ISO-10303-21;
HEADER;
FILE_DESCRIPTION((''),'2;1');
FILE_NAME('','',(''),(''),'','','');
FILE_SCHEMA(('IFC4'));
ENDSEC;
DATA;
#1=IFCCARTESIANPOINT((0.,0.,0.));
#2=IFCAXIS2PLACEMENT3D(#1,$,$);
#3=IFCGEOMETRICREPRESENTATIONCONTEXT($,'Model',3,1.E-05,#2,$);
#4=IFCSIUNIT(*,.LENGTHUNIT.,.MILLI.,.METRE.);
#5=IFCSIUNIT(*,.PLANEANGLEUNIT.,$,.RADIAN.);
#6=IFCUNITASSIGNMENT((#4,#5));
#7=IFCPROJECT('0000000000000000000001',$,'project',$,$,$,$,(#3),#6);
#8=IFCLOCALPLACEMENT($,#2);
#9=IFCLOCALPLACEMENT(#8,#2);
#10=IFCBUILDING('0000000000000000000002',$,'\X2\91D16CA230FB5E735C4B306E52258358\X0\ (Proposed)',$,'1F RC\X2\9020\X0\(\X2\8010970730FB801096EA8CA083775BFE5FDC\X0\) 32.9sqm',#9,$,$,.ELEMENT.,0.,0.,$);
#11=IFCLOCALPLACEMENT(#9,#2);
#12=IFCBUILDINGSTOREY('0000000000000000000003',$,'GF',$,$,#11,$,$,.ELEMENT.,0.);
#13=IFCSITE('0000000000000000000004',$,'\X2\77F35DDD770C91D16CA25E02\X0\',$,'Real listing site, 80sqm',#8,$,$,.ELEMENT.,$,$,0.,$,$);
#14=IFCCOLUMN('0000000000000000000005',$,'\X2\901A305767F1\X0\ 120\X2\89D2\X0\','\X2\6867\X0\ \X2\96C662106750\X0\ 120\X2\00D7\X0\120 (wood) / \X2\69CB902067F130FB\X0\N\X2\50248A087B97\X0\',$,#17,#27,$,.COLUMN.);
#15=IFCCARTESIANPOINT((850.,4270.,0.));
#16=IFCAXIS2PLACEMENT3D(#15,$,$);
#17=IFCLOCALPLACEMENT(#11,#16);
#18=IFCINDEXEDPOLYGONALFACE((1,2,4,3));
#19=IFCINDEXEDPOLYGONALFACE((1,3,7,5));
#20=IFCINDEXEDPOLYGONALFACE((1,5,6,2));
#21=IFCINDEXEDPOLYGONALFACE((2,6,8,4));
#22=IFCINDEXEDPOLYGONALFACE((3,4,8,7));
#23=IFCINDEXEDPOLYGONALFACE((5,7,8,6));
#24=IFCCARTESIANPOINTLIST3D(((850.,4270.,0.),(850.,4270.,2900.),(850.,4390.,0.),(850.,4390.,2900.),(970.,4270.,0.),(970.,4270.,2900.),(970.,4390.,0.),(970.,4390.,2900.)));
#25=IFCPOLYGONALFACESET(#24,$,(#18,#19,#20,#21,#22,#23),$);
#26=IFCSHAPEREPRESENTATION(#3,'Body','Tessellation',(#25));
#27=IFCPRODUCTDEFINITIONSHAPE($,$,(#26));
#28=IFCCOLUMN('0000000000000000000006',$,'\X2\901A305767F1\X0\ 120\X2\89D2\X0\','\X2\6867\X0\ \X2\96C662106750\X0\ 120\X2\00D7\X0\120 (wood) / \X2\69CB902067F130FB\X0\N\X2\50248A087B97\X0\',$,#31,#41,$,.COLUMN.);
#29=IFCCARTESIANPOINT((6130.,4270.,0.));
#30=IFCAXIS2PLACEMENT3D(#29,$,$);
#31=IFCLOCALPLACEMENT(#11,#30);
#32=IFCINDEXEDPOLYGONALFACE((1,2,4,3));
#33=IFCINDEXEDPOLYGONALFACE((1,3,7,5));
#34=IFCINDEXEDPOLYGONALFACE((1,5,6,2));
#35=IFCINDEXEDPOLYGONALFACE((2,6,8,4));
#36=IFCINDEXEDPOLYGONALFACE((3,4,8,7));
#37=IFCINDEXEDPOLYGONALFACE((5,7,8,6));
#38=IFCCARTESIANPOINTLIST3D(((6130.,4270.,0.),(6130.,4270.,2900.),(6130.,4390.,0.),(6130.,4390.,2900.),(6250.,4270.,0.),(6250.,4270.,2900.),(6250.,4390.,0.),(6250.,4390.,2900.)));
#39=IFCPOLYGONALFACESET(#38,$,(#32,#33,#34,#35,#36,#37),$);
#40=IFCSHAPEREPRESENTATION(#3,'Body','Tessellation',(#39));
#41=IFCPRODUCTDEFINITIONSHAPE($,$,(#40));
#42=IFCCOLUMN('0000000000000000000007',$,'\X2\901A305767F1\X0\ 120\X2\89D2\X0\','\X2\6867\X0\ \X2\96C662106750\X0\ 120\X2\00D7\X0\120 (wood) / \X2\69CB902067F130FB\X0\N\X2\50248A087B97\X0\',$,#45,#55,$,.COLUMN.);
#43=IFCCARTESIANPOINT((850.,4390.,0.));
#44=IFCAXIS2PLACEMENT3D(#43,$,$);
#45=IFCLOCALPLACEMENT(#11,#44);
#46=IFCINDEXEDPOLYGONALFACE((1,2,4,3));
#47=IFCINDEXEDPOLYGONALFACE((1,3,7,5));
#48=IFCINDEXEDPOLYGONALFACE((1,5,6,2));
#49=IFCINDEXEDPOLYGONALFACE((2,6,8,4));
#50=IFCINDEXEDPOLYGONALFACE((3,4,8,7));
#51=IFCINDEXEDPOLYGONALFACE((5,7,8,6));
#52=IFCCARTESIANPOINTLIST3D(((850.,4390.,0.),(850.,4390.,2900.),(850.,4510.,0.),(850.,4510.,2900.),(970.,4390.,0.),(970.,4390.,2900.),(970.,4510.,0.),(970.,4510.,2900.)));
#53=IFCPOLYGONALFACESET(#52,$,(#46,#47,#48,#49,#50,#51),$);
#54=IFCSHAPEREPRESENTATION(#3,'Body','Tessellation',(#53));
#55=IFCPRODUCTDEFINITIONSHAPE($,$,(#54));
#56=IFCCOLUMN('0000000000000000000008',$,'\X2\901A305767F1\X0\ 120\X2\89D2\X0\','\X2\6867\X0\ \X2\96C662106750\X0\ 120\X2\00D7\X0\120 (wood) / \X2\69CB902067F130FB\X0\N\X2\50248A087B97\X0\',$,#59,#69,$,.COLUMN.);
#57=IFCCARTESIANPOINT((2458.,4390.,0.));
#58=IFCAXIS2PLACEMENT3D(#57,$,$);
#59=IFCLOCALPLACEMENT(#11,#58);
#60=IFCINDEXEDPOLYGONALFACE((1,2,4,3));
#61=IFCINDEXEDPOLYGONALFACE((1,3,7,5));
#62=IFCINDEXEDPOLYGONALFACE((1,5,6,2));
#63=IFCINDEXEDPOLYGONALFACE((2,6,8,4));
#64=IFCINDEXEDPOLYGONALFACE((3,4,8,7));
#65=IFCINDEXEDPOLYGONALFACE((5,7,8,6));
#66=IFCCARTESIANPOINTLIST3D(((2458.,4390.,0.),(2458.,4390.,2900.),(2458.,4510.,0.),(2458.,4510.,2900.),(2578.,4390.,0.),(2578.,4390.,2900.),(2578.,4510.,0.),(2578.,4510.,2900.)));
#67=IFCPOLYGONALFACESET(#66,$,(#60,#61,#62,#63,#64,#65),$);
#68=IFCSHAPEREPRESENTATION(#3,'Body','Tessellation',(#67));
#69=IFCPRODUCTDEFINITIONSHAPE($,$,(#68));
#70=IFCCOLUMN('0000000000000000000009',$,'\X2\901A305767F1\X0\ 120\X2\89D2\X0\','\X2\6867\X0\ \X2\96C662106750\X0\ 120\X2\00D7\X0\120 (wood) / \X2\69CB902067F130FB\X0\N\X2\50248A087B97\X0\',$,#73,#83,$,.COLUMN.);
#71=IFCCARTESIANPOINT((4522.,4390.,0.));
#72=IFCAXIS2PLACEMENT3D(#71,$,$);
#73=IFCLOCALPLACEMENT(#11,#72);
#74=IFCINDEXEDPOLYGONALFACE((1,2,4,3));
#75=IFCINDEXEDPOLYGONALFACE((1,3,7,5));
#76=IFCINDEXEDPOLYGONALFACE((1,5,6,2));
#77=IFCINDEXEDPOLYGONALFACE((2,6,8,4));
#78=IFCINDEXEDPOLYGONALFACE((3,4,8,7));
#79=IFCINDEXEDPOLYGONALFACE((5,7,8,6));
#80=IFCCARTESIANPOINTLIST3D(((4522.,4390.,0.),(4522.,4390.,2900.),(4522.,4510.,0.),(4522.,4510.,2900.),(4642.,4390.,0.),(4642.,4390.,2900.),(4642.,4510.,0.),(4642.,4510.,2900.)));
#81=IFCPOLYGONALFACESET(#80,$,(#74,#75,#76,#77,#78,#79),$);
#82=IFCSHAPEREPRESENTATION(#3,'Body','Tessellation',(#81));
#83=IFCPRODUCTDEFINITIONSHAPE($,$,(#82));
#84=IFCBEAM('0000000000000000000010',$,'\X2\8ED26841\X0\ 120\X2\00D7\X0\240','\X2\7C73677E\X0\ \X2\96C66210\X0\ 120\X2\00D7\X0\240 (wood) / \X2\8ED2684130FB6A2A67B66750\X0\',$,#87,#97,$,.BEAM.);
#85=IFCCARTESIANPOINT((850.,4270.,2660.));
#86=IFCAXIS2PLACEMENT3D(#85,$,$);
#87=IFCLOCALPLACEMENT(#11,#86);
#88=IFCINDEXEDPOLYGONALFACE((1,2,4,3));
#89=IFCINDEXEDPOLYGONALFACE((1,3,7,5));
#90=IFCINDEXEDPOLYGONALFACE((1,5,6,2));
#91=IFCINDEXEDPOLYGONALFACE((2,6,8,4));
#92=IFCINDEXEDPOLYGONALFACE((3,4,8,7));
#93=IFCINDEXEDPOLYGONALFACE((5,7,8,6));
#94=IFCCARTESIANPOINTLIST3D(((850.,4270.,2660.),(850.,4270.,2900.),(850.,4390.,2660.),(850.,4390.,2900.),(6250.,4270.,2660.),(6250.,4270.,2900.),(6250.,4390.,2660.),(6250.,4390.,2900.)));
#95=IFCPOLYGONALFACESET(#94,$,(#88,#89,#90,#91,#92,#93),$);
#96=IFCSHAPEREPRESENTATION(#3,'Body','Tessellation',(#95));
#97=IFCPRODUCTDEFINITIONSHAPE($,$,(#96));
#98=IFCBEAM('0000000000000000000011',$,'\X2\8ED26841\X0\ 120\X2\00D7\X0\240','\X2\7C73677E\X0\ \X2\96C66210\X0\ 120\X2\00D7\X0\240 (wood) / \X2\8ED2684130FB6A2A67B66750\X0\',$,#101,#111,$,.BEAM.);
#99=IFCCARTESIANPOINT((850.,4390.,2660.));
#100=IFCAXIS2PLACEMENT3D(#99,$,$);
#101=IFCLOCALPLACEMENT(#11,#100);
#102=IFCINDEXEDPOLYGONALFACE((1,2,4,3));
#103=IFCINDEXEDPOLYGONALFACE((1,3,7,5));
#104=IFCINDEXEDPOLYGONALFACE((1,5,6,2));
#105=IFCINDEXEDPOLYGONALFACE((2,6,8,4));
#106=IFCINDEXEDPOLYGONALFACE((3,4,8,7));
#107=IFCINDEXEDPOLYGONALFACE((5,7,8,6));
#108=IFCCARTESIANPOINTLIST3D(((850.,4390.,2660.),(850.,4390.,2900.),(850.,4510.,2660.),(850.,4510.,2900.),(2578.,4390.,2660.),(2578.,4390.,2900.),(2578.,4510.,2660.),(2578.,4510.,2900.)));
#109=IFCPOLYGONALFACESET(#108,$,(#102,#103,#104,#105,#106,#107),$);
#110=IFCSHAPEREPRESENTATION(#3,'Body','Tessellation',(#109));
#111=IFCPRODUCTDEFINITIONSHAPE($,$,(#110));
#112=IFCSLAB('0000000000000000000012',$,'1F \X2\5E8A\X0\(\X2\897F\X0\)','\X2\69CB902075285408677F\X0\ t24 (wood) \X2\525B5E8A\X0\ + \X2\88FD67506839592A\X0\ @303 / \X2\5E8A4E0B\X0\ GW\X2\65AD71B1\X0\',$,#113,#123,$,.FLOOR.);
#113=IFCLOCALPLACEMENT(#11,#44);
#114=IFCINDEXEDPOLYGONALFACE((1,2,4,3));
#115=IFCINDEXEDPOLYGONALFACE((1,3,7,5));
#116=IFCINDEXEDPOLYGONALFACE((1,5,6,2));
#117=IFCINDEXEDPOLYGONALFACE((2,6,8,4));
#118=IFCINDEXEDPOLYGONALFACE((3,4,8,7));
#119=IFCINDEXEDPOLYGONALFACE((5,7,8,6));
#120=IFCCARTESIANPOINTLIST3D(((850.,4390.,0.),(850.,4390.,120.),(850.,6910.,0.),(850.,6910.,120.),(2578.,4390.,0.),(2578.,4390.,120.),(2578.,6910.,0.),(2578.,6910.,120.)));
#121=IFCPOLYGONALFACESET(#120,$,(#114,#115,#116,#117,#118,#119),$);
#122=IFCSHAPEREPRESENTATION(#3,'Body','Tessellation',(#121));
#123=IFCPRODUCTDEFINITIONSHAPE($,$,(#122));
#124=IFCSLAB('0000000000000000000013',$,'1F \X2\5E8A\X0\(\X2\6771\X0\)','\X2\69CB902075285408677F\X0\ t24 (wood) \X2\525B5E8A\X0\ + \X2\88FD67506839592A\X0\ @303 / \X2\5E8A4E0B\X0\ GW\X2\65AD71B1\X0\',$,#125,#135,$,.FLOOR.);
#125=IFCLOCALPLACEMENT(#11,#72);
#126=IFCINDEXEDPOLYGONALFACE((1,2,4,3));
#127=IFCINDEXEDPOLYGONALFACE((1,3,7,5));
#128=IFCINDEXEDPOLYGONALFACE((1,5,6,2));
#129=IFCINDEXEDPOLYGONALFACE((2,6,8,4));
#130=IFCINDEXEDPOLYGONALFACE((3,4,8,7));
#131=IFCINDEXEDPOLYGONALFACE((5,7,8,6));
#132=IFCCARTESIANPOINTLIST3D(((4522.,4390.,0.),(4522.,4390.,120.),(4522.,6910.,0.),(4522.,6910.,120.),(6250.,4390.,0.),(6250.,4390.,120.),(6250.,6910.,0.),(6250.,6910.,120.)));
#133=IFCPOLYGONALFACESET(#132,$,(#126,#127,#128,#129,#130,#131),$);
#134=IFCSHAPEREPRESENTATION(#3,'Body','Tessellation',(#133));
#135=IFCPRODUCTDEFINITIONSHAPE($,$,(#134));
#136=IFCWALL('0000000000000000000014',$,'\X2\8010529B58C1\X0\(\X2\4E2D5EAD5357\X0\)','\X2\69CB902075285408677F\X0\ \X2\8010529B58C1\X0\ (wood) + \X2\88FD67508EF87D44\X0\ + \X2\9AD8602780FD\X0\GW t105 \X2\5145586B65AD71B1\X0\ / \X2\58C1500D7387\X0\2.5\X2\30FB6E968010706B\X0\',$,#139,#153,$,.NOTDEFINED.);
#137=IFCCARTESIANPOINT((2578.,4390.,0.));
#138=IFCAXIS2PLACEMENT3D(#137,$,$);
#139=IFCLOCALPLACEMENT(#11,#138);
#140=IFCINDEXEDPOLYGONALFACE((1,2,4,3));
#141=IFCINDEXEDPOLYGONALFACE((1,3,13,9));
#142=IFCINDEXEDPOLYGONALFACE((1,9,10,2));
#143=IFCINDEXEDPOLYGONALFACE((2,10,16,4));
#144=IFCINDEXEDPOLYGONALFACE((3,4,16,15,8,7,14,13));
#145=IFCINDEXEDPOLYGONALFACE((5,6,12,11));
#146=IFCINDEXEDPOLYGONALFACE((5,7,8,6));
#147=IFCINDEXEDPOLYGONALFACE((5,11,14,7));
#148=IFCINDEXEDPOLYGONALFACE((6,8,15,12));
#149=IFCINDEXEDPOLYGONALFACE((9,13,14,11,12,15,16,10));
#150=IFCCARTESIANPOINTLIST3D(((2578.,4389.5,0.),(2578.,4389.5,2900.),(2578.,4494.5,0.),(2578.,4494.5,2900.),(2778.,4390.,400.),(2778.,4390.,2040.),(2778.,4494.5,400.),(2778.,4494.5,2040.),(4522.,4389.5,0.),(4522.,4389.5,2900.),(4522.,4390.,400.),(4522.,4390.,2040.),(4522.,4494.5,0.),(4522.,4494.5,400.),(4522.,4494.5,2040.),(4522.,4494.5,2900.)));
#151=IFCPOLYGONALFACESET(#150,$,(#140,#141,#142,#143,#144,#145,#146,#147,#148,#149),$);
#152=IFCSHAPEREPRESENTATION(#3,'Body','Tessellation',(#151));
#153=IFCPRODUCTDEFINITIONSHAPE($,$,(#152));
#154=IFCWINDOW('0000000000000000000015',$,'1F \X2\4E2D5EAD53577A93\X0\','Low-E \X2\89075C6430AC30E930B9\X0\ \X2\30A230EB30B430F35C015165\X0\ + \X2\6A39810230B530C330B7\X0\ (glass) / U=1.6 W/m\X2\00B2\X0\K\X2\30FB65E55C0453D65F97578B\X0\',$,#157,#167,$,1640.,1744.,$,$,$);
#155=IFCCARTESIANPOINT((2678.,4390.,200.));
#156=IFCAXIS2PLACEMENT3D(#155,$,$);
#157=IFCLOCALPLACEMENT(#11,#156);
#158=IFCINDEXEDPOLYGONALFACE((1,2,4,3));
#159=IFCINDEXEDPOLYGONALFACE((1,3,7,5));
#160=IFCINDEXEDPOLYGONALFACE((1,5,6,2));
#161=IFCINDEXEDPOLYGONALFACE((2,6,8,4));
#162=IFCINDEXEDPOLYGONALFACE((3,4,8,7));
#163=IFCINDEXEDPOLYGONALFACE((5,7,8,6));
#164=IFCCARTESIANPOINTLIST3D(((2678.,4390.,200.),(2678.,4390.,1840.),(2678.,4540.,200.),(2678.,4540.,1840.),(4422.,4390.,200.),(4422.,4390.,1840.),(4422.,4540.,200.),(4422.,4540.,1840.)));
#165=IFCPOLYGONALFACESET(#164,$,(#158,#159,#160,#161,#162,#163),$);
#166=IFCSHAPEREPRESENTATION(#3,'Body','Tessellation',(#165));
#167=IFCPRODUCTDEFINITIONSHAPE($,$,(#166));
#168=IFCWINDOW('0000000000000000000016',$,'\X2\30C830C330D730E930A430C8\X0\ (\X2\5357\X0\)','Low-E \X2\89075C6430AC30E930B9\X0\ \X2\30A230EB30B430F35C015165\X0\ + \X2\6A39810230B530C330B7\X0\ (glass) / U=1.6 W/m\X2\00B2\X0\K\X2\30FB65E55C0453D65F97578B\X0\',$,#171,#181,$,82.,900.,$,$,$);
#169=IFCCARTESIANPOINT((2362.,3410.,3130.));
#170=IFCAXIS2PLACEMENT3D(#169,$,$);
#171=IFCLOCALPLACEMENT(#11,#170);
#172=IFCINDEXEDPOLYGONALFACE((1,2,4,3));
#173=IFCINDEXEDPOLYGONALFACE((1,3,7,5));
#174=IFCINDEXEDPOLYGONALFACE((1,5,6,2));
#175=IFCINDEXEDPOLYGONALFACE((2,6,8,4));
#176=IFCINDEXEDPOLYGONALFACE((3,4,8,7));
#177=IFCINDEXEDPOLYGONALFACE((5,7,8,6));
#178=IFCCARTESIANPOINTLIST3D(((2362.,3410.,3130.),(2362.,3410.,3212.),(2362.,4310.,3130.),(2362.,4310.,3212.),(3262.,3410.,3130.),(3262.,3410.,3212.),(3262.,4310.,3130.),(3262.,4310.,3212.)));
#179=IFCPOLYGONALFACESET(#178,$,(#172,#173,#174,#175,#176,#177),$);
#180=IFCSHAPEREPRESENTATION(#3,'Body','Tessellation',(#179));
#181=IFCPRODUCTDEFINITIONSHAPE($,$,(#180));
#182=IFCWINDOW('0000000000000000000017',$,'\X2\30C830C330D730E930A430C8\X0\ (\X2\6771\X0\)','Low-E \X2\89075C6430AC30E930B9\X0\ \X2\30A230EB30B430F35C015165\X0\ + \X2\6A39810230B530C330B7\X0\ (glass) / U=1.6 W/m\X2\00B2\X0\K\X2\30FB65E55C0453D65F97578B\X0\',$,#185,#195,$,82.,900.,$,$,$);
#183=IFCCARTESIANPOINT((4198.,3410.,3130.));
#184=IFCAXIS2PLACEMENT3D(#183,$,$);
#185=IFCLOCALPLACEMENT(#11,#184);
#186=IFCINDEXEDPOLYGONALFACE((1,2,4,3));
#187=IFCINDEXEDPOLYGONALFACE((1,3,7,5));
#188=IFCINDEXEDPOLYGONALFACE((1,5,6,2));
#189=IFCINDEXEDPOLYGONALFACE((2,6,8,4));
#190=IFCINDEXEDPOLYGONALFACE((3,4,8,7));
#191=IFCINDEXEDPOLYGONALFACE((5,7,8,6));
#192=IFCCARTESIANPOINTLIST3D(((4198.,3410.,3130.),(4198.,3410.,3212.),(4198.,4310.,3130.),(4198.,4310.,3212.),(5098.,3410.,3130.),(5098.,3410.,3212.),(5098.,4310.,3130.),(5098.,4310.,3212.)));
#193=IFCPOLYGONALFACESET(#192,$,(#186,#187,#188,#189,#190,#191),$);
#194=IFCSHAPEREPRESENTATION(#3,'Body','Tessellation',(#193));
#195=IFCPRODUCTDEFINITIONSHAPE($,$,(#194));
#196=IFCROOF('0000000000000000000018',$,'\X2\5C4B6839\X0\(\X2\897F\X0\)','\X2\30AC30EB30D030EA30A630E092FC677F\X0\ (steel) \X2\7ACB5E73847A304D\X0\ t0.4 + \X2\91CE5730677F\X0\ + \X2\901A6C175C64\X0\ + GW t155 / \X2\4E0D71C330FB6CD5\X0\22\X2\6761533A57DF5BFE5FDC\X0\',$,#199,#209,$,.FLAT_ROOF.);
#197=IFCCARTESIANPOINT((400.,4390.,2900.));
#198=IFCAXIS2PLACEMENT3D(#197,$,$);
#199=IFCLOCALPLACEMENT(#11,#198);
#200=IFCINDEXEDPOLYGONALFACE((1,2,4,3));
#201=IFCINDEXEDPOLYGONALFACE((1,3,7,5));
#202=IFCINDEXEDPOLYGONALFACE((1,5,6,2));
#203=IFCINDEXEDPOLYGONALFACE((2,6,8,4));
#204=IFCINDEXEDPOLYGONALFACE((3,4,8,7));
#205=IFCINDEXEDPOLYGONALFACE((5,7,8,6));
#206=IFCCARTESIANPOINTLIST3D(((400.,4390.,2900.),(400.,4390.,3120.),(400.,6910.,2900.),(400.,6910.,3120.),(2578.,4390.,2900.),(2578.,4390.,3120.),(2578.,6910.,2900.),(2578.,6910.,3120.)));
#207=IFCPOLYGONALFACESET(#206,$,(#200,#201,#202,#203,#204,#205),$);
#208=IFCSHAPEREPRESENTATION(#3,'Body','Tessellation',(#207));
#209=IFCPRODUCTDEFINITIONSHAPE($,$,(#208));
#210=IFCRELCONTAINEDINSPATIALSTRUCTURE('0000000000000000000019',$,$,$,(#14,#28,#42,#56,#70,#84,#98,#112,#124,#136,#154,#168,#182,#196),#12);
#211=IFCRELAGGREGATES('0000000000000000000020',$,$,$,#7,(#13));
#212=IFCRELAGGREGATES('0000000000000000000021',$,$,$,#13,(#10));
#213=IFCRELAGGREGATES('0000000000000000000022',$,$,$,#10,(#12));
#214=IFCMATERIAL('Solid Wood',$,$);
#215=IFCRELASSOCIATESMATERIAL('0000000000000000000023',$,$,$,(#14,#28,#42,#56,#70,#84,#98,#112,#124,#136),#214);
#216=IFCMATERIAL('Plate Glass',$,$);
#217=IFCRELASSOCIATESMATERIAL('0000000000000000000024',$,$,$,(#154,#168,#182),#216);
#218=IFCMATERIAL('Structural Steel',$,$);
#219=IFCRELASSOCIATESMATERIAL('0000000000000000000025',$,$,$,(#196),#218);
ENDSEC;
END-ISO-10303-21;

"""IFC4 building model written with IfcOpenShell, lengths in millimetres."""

from ifc_helpers import new_model, si_unit, frame, frame_2d, origin, place, context, project, spatial, rectangle, extrude, material, element, fill, save


model = new_model("IFC4")

# Units and contexts
model_context = context("Model", 3, precision=1e-05, world=origin())
ifc_project = project(units=[si_unit("LENGTHUNIT", "METRE", prefix="MILLI"), si_unit("PLANEANGLEUNIT", "RADIAN")], contexts=[model_context])

# Site, building, storey
site_placement = place(None, origin())
site = spatial("IfcSite", under=ifc_project, at=site_placement, Name="石川県金沢市", ObjectType="Real listing site, 80sqm", CompositionType="ELEMENT", RefElevation=0.0)
building_placement = place(site_placement, origin())
building = spatial("IfcBuilding", under=site, at=building_placement, Name="金沢・平屋の別荘 (Proposed)", ObjectType="1F RC造(耐震・耐雪負荷対応) 32.9sqm", CompositionType="ELEMENT", ElevationOfRefHeight=0.0, ElevationOfTerrain=0.0)
storey_placement = place(building_placement, origin())
storey = spatial("IfcBuildingStorey", under=building, at=storey_placement, Name="GF", CompositionType="ELEMENT", Elevation=0.0)

# Columns
ifc_material_1 = material(Name="Solid Wood")
column_1_placement = place(storey_placement, frame((850.0, 4270.0, 0.0)))
element("IfcColumn", 1, at=column_1_placement, inside=storey, material=ifc_material_1, Name="通し柱 120角", Description="桧 集成材 120×120 (wood) / 構造柱・N値計算", PredefinedType="COLUMN", context=model_context, shape_type="SweptSolid", body=[
    extrude(rectangle(XDim=120.0, YDim=120.0, at=frame_2d((60.0, 60.0))), frame((850.0, 4270.0, 0.0)), (0.0, 0.0, 1.0), 2900.0),
])
column_2_placement = place(storey_placement, frame((6130.0, 4270.0, 0.0)))
element("IfcColumn", 2, at=column_2_placement, inside=storey, material=ifc_material_1, Name="通し柱 120角", Description="桧 集成材 120×120 (wood) / 構造柱・N値計算", PredefinedType="COLUMN", context=model_context, shape_type="SweptSolid", body=[
    extrude(rectangle(XDim=120.0, YDim=120.0, at=frame_2d((60.0, 60.0))), frame((6130.0, 4270.0, 0.0)), (0.0, 0.0, 1.0), 2900.0),
])
column_3_placement = place(storey_placement, frame((850.0, 4390.0, 0.0)))
element("IfcColumn", 3, at=column_3_placement, inside=storey, material=ifc_material_1, Name="通し柱 120角", Description="桧 集成材 120×120 (wood) / 構造柱・N値計算", PredefinedType="COLUMN", context=model_context, shape_type="SweptSolid", body=[
    extrude(rectangle(XDim=120.0, YDim=120.0, at=frame_2d((60.0, 60.0))), frame((850.0, 4390.0, 0.0)), (0.0, 0.0, 1.0), 2900.0),
])
column_4_placement = place(storey_placement, frame((2458.0, 4390.0, 0.0)))
element("IfcColumn", 4, at=column_4_placement, inside=storey, material=ifc_material_1, Name="通し柱 120角", Description="桧 集成材 120×120 (wood) / 構造柱・N値計算", PredefinedType="COLUMN", context=model_context, shape_type="SweptSolid", body=[
    extrude(rectangle(XDim=120.0, YDim=120.0, at=frame_2d((60.0, 60.0))), frame((2458.0, 4390.0, 0.0)), (0.0, 0.0, 1.0), 2900.0),
])
column_5_placement = place(storey_placement, frame((4522.0, 4390.0, 0.0)))
element("IfcColumn", 5, at=column_5_placement, inside=storey, material=ifc_material_1, Name="通し柱 120角", Description="桧 集成材 120×120 (wood) / 構造柱・N値計算", PredefinedType="COLUMN", context=model_context, shape_type="SweptSolid", body=[
    extrude(rectangle(XDim=120.0, YDim=120.0, at=frame_2d((60.0, 60.0))), frame((4522.0, 4390.0, 0.0)), (0.0, 0.0, 1.0), 2900.0),
])

# Beams
beam_1_placement = place(storey_placement, frame((850.0, 4270.0, 2660.0)))
element("IfcBeam", 6, at=beam_1_placement, inside=storey, material=ifc_material_1, Name="軒桁 120×240", Description="米松 集成 120×240 (wood) / 軒桁・横架材", PredefinedType="BEAM", context=model_context, shape_type="SweptSolid", body=[
    extrude(rectangle(XDim=5400.0, YDim=120.0, at=frame_2d((2700.0, 60.0))), frame((850.0, 4270.0, 2660.0)), (0.0, 0.0, 1.0), 240.0),
])
beam_2_placement = place(storey_placement, frame((850.0, 4390.0, 2660.0)))
element("IfcBeam", 7, at=beam_2_placement, inside=storey, material=ifc_material_1, Name="軒桁 120×240", Description="米松 集成 120×240 (wood) / 軒桁・横架材", PredefinedType="BEAM", context=model_context, shape_type="SweptSolid", body=[
    extrude(rectangle(XDim=1728.0, YDim=120.0, at=frame_2d((864.0, 60.0))), frame((850.0, 4390.0, 2660.0)), (0.0, 0.0, 1.0), 240.0),
])

# Slabs
slab_1_placement = place(storey_placement, frame((850.0, 4390.0, 0.0)))
element("IfcSlab", 8, at=slab_1_placement, inside=storey, material=ifc_material_1, Name="1F 床(西)", Description="構造用合板 t24 (wood) 剛床 + 製材根太 @303 / 床下 GW断熱", PredefinedType="FLOOR", context=model_context, shape_type="SweptSolid", body=[
    extrude(rectangle(XDim=1728.0, YDim=2520.0, at=frame_2d((864.0, 1260.0))), frame((850.0, 4390.0, 0.0)), (0.0, 0.0, 1.0), 120.0),
])
slab_2_placement = place(storey_placement, frame((4522.0, 4390.0, 0.0)))
element("IfcSlab", 9, at=slab_2_placement, inside=storey, material=ifc_material_1, Name="1F 床(東)", Description="構造用合板 t24 (wood) 剛床 + 製材根太 @303 / 床下 GW断熱", PredefinedType="FLOOR", context=model_context, shape_type="SweptSolid", body=[
    extrude(rectangle(XDim=1728.0, YDim=2520.0, at=frame_2d((864.0, 1260.0))), frame((4522.0, 4390.0, 0.0)), (0.0, 0.0, 1.0), 120.0),
])

# Wall, opening, window
wall_1_placement = place(storey_placement, frame((2578.0, 4390.0, 0.0)))
wall_1 = element("IfcWall", 10, at=wall_1_placement, inside=storey, material=ifc_material_1, Name="耐力壁(中庭南)", Description="構造用合板 耐力壁 (wood) + 製材軸組 + 高性能GW t105 充填断熱 / 壁倍率2.5・準耐火", PredefinedType="NOTDEFINED", context=model_context, shape_type="SweptSolid", body=[
    extrude(rectangle(XDim=1944.0, YDim=105.0, at=frame_2d((972.0, 52.0))), frame((2578.0, 4390.0, 0.0)), (0.0, 0.0, 1.0), 2900.0),
])
opening_placement = place(storey_placement, frame((2678.0, 4390.0, 200.0)))
opening = element("IfcOpeningElement", 11, at=opening_placement, cuts=wall_1, PredefinedType="NOTDEFINED", context=model_context, shape_type="SweptSolid", body=[
    extrude(rectangle(XDim=1744.0, YDim=150.0, at=frame_2d((872.0, 75.0))), frame((2678.0, 4390.0, 200.0)), (0.0, 0.0, 1.0), 1640.0),
])
ifc_material_2 = material(Name="Plate Glass")
window_1_placement = place(storey_placement, frame((2678.0, 4390.0, 200.0)))
window_1 = element("IfcWindow", 12, at=window_1_placement, inside=storey, material=ifc_material_2, Name="1F 中庭南窓", Description="Low-E 複層ガラス アルゴン封入 + 樹脂サッシ (glass) / U=1.6 W/m²K・日射取得型", OverallHeight=1640.0, OverallWidth=1744.0, context=model_context, shape_type="SweptSolid", body=[
    extrude(rectangle(XDim=1744.0, YDim=150.0, at=frame_2d((872.0, 75.0))), frame((2678.0, 4390.0, 200.0)), (0.0, 0.0, 1.0), 1640.0),
])
fill(opening, window_1)

# Windows
window_2_placement = place(storey_placement, frame((2362.0, 3410.0, 3130.0)))
element("IfcWindow", 13, at=window_2_placement, inside=storey, material=ifc_material_2, Name="トップライト (南)", Description="Low-E 複層ガラス アルゴン封入 + 樹脂サッシ (glass) / U=1.6 W/m²K・日射取得型", OverallHeight=82.0, OverallWidth=900.0, context=model_context, shape_type="SweptSolid", body=[
    extrude(rectangle(XDim=900.0, YDim=900.0, at=frame_2d((450.0, 450.0))), frame((2362.0, 3410.0, 3130.0)), (0.0, 0.0, 1.0), 82.0),
])
window_3_placement = place(storey_placement, frame((4198.0, 3410.0, 3130.0)))
element("IfcWindow", 14, at=window_3_placement, inside=storey, material=ifc_material_2, Name="トップライト (東)", Description="Low-E 複層ガラス アルゴン封入 + 樹脂サッシ (glass) / U=1.6 W/m²K・日射取得型", OverallHeight=82.0, OverallWidth=900.0, context=model_context, shape_type="SweptSolid", body=[
    extrude(rectangle(XDim=900.0, YDim=900.0, at=frame_2d((450.0, 450.0))), frame((4198.0, 3410.0, 3130.0)), (0.0, 0.0, 1.0), 82.0),
])

# Roof
ifc_material_3 = material(Name="Structural Steel")
roof_1_placement = place(storey_placement, frame((400.0, 4390.0, 2900.0)))
element("IfcRoof", 15, at=roof_1_placement, inside=storey, material=ifc_material_3, Name="屋根(西)", Description="ガルバリウム鋼板 (steel) 立平葺き t0.4 + 野地板 + 通気層 + GW t155 / 不燃・法22条区域対応", PredefinedType="FLAT_ROOF", context=model_context, shape_type="SweptSolid", body=[
    extrude(rectangle(XDim=2178.0, YDim=2520.0, at=frame_2d((1089.0, 1260.0))), frame((400.0, 4390.0, 2900.0)), (0.0, 0.0, 1.0), 220.0),
])

save(model, "model.ifc")
